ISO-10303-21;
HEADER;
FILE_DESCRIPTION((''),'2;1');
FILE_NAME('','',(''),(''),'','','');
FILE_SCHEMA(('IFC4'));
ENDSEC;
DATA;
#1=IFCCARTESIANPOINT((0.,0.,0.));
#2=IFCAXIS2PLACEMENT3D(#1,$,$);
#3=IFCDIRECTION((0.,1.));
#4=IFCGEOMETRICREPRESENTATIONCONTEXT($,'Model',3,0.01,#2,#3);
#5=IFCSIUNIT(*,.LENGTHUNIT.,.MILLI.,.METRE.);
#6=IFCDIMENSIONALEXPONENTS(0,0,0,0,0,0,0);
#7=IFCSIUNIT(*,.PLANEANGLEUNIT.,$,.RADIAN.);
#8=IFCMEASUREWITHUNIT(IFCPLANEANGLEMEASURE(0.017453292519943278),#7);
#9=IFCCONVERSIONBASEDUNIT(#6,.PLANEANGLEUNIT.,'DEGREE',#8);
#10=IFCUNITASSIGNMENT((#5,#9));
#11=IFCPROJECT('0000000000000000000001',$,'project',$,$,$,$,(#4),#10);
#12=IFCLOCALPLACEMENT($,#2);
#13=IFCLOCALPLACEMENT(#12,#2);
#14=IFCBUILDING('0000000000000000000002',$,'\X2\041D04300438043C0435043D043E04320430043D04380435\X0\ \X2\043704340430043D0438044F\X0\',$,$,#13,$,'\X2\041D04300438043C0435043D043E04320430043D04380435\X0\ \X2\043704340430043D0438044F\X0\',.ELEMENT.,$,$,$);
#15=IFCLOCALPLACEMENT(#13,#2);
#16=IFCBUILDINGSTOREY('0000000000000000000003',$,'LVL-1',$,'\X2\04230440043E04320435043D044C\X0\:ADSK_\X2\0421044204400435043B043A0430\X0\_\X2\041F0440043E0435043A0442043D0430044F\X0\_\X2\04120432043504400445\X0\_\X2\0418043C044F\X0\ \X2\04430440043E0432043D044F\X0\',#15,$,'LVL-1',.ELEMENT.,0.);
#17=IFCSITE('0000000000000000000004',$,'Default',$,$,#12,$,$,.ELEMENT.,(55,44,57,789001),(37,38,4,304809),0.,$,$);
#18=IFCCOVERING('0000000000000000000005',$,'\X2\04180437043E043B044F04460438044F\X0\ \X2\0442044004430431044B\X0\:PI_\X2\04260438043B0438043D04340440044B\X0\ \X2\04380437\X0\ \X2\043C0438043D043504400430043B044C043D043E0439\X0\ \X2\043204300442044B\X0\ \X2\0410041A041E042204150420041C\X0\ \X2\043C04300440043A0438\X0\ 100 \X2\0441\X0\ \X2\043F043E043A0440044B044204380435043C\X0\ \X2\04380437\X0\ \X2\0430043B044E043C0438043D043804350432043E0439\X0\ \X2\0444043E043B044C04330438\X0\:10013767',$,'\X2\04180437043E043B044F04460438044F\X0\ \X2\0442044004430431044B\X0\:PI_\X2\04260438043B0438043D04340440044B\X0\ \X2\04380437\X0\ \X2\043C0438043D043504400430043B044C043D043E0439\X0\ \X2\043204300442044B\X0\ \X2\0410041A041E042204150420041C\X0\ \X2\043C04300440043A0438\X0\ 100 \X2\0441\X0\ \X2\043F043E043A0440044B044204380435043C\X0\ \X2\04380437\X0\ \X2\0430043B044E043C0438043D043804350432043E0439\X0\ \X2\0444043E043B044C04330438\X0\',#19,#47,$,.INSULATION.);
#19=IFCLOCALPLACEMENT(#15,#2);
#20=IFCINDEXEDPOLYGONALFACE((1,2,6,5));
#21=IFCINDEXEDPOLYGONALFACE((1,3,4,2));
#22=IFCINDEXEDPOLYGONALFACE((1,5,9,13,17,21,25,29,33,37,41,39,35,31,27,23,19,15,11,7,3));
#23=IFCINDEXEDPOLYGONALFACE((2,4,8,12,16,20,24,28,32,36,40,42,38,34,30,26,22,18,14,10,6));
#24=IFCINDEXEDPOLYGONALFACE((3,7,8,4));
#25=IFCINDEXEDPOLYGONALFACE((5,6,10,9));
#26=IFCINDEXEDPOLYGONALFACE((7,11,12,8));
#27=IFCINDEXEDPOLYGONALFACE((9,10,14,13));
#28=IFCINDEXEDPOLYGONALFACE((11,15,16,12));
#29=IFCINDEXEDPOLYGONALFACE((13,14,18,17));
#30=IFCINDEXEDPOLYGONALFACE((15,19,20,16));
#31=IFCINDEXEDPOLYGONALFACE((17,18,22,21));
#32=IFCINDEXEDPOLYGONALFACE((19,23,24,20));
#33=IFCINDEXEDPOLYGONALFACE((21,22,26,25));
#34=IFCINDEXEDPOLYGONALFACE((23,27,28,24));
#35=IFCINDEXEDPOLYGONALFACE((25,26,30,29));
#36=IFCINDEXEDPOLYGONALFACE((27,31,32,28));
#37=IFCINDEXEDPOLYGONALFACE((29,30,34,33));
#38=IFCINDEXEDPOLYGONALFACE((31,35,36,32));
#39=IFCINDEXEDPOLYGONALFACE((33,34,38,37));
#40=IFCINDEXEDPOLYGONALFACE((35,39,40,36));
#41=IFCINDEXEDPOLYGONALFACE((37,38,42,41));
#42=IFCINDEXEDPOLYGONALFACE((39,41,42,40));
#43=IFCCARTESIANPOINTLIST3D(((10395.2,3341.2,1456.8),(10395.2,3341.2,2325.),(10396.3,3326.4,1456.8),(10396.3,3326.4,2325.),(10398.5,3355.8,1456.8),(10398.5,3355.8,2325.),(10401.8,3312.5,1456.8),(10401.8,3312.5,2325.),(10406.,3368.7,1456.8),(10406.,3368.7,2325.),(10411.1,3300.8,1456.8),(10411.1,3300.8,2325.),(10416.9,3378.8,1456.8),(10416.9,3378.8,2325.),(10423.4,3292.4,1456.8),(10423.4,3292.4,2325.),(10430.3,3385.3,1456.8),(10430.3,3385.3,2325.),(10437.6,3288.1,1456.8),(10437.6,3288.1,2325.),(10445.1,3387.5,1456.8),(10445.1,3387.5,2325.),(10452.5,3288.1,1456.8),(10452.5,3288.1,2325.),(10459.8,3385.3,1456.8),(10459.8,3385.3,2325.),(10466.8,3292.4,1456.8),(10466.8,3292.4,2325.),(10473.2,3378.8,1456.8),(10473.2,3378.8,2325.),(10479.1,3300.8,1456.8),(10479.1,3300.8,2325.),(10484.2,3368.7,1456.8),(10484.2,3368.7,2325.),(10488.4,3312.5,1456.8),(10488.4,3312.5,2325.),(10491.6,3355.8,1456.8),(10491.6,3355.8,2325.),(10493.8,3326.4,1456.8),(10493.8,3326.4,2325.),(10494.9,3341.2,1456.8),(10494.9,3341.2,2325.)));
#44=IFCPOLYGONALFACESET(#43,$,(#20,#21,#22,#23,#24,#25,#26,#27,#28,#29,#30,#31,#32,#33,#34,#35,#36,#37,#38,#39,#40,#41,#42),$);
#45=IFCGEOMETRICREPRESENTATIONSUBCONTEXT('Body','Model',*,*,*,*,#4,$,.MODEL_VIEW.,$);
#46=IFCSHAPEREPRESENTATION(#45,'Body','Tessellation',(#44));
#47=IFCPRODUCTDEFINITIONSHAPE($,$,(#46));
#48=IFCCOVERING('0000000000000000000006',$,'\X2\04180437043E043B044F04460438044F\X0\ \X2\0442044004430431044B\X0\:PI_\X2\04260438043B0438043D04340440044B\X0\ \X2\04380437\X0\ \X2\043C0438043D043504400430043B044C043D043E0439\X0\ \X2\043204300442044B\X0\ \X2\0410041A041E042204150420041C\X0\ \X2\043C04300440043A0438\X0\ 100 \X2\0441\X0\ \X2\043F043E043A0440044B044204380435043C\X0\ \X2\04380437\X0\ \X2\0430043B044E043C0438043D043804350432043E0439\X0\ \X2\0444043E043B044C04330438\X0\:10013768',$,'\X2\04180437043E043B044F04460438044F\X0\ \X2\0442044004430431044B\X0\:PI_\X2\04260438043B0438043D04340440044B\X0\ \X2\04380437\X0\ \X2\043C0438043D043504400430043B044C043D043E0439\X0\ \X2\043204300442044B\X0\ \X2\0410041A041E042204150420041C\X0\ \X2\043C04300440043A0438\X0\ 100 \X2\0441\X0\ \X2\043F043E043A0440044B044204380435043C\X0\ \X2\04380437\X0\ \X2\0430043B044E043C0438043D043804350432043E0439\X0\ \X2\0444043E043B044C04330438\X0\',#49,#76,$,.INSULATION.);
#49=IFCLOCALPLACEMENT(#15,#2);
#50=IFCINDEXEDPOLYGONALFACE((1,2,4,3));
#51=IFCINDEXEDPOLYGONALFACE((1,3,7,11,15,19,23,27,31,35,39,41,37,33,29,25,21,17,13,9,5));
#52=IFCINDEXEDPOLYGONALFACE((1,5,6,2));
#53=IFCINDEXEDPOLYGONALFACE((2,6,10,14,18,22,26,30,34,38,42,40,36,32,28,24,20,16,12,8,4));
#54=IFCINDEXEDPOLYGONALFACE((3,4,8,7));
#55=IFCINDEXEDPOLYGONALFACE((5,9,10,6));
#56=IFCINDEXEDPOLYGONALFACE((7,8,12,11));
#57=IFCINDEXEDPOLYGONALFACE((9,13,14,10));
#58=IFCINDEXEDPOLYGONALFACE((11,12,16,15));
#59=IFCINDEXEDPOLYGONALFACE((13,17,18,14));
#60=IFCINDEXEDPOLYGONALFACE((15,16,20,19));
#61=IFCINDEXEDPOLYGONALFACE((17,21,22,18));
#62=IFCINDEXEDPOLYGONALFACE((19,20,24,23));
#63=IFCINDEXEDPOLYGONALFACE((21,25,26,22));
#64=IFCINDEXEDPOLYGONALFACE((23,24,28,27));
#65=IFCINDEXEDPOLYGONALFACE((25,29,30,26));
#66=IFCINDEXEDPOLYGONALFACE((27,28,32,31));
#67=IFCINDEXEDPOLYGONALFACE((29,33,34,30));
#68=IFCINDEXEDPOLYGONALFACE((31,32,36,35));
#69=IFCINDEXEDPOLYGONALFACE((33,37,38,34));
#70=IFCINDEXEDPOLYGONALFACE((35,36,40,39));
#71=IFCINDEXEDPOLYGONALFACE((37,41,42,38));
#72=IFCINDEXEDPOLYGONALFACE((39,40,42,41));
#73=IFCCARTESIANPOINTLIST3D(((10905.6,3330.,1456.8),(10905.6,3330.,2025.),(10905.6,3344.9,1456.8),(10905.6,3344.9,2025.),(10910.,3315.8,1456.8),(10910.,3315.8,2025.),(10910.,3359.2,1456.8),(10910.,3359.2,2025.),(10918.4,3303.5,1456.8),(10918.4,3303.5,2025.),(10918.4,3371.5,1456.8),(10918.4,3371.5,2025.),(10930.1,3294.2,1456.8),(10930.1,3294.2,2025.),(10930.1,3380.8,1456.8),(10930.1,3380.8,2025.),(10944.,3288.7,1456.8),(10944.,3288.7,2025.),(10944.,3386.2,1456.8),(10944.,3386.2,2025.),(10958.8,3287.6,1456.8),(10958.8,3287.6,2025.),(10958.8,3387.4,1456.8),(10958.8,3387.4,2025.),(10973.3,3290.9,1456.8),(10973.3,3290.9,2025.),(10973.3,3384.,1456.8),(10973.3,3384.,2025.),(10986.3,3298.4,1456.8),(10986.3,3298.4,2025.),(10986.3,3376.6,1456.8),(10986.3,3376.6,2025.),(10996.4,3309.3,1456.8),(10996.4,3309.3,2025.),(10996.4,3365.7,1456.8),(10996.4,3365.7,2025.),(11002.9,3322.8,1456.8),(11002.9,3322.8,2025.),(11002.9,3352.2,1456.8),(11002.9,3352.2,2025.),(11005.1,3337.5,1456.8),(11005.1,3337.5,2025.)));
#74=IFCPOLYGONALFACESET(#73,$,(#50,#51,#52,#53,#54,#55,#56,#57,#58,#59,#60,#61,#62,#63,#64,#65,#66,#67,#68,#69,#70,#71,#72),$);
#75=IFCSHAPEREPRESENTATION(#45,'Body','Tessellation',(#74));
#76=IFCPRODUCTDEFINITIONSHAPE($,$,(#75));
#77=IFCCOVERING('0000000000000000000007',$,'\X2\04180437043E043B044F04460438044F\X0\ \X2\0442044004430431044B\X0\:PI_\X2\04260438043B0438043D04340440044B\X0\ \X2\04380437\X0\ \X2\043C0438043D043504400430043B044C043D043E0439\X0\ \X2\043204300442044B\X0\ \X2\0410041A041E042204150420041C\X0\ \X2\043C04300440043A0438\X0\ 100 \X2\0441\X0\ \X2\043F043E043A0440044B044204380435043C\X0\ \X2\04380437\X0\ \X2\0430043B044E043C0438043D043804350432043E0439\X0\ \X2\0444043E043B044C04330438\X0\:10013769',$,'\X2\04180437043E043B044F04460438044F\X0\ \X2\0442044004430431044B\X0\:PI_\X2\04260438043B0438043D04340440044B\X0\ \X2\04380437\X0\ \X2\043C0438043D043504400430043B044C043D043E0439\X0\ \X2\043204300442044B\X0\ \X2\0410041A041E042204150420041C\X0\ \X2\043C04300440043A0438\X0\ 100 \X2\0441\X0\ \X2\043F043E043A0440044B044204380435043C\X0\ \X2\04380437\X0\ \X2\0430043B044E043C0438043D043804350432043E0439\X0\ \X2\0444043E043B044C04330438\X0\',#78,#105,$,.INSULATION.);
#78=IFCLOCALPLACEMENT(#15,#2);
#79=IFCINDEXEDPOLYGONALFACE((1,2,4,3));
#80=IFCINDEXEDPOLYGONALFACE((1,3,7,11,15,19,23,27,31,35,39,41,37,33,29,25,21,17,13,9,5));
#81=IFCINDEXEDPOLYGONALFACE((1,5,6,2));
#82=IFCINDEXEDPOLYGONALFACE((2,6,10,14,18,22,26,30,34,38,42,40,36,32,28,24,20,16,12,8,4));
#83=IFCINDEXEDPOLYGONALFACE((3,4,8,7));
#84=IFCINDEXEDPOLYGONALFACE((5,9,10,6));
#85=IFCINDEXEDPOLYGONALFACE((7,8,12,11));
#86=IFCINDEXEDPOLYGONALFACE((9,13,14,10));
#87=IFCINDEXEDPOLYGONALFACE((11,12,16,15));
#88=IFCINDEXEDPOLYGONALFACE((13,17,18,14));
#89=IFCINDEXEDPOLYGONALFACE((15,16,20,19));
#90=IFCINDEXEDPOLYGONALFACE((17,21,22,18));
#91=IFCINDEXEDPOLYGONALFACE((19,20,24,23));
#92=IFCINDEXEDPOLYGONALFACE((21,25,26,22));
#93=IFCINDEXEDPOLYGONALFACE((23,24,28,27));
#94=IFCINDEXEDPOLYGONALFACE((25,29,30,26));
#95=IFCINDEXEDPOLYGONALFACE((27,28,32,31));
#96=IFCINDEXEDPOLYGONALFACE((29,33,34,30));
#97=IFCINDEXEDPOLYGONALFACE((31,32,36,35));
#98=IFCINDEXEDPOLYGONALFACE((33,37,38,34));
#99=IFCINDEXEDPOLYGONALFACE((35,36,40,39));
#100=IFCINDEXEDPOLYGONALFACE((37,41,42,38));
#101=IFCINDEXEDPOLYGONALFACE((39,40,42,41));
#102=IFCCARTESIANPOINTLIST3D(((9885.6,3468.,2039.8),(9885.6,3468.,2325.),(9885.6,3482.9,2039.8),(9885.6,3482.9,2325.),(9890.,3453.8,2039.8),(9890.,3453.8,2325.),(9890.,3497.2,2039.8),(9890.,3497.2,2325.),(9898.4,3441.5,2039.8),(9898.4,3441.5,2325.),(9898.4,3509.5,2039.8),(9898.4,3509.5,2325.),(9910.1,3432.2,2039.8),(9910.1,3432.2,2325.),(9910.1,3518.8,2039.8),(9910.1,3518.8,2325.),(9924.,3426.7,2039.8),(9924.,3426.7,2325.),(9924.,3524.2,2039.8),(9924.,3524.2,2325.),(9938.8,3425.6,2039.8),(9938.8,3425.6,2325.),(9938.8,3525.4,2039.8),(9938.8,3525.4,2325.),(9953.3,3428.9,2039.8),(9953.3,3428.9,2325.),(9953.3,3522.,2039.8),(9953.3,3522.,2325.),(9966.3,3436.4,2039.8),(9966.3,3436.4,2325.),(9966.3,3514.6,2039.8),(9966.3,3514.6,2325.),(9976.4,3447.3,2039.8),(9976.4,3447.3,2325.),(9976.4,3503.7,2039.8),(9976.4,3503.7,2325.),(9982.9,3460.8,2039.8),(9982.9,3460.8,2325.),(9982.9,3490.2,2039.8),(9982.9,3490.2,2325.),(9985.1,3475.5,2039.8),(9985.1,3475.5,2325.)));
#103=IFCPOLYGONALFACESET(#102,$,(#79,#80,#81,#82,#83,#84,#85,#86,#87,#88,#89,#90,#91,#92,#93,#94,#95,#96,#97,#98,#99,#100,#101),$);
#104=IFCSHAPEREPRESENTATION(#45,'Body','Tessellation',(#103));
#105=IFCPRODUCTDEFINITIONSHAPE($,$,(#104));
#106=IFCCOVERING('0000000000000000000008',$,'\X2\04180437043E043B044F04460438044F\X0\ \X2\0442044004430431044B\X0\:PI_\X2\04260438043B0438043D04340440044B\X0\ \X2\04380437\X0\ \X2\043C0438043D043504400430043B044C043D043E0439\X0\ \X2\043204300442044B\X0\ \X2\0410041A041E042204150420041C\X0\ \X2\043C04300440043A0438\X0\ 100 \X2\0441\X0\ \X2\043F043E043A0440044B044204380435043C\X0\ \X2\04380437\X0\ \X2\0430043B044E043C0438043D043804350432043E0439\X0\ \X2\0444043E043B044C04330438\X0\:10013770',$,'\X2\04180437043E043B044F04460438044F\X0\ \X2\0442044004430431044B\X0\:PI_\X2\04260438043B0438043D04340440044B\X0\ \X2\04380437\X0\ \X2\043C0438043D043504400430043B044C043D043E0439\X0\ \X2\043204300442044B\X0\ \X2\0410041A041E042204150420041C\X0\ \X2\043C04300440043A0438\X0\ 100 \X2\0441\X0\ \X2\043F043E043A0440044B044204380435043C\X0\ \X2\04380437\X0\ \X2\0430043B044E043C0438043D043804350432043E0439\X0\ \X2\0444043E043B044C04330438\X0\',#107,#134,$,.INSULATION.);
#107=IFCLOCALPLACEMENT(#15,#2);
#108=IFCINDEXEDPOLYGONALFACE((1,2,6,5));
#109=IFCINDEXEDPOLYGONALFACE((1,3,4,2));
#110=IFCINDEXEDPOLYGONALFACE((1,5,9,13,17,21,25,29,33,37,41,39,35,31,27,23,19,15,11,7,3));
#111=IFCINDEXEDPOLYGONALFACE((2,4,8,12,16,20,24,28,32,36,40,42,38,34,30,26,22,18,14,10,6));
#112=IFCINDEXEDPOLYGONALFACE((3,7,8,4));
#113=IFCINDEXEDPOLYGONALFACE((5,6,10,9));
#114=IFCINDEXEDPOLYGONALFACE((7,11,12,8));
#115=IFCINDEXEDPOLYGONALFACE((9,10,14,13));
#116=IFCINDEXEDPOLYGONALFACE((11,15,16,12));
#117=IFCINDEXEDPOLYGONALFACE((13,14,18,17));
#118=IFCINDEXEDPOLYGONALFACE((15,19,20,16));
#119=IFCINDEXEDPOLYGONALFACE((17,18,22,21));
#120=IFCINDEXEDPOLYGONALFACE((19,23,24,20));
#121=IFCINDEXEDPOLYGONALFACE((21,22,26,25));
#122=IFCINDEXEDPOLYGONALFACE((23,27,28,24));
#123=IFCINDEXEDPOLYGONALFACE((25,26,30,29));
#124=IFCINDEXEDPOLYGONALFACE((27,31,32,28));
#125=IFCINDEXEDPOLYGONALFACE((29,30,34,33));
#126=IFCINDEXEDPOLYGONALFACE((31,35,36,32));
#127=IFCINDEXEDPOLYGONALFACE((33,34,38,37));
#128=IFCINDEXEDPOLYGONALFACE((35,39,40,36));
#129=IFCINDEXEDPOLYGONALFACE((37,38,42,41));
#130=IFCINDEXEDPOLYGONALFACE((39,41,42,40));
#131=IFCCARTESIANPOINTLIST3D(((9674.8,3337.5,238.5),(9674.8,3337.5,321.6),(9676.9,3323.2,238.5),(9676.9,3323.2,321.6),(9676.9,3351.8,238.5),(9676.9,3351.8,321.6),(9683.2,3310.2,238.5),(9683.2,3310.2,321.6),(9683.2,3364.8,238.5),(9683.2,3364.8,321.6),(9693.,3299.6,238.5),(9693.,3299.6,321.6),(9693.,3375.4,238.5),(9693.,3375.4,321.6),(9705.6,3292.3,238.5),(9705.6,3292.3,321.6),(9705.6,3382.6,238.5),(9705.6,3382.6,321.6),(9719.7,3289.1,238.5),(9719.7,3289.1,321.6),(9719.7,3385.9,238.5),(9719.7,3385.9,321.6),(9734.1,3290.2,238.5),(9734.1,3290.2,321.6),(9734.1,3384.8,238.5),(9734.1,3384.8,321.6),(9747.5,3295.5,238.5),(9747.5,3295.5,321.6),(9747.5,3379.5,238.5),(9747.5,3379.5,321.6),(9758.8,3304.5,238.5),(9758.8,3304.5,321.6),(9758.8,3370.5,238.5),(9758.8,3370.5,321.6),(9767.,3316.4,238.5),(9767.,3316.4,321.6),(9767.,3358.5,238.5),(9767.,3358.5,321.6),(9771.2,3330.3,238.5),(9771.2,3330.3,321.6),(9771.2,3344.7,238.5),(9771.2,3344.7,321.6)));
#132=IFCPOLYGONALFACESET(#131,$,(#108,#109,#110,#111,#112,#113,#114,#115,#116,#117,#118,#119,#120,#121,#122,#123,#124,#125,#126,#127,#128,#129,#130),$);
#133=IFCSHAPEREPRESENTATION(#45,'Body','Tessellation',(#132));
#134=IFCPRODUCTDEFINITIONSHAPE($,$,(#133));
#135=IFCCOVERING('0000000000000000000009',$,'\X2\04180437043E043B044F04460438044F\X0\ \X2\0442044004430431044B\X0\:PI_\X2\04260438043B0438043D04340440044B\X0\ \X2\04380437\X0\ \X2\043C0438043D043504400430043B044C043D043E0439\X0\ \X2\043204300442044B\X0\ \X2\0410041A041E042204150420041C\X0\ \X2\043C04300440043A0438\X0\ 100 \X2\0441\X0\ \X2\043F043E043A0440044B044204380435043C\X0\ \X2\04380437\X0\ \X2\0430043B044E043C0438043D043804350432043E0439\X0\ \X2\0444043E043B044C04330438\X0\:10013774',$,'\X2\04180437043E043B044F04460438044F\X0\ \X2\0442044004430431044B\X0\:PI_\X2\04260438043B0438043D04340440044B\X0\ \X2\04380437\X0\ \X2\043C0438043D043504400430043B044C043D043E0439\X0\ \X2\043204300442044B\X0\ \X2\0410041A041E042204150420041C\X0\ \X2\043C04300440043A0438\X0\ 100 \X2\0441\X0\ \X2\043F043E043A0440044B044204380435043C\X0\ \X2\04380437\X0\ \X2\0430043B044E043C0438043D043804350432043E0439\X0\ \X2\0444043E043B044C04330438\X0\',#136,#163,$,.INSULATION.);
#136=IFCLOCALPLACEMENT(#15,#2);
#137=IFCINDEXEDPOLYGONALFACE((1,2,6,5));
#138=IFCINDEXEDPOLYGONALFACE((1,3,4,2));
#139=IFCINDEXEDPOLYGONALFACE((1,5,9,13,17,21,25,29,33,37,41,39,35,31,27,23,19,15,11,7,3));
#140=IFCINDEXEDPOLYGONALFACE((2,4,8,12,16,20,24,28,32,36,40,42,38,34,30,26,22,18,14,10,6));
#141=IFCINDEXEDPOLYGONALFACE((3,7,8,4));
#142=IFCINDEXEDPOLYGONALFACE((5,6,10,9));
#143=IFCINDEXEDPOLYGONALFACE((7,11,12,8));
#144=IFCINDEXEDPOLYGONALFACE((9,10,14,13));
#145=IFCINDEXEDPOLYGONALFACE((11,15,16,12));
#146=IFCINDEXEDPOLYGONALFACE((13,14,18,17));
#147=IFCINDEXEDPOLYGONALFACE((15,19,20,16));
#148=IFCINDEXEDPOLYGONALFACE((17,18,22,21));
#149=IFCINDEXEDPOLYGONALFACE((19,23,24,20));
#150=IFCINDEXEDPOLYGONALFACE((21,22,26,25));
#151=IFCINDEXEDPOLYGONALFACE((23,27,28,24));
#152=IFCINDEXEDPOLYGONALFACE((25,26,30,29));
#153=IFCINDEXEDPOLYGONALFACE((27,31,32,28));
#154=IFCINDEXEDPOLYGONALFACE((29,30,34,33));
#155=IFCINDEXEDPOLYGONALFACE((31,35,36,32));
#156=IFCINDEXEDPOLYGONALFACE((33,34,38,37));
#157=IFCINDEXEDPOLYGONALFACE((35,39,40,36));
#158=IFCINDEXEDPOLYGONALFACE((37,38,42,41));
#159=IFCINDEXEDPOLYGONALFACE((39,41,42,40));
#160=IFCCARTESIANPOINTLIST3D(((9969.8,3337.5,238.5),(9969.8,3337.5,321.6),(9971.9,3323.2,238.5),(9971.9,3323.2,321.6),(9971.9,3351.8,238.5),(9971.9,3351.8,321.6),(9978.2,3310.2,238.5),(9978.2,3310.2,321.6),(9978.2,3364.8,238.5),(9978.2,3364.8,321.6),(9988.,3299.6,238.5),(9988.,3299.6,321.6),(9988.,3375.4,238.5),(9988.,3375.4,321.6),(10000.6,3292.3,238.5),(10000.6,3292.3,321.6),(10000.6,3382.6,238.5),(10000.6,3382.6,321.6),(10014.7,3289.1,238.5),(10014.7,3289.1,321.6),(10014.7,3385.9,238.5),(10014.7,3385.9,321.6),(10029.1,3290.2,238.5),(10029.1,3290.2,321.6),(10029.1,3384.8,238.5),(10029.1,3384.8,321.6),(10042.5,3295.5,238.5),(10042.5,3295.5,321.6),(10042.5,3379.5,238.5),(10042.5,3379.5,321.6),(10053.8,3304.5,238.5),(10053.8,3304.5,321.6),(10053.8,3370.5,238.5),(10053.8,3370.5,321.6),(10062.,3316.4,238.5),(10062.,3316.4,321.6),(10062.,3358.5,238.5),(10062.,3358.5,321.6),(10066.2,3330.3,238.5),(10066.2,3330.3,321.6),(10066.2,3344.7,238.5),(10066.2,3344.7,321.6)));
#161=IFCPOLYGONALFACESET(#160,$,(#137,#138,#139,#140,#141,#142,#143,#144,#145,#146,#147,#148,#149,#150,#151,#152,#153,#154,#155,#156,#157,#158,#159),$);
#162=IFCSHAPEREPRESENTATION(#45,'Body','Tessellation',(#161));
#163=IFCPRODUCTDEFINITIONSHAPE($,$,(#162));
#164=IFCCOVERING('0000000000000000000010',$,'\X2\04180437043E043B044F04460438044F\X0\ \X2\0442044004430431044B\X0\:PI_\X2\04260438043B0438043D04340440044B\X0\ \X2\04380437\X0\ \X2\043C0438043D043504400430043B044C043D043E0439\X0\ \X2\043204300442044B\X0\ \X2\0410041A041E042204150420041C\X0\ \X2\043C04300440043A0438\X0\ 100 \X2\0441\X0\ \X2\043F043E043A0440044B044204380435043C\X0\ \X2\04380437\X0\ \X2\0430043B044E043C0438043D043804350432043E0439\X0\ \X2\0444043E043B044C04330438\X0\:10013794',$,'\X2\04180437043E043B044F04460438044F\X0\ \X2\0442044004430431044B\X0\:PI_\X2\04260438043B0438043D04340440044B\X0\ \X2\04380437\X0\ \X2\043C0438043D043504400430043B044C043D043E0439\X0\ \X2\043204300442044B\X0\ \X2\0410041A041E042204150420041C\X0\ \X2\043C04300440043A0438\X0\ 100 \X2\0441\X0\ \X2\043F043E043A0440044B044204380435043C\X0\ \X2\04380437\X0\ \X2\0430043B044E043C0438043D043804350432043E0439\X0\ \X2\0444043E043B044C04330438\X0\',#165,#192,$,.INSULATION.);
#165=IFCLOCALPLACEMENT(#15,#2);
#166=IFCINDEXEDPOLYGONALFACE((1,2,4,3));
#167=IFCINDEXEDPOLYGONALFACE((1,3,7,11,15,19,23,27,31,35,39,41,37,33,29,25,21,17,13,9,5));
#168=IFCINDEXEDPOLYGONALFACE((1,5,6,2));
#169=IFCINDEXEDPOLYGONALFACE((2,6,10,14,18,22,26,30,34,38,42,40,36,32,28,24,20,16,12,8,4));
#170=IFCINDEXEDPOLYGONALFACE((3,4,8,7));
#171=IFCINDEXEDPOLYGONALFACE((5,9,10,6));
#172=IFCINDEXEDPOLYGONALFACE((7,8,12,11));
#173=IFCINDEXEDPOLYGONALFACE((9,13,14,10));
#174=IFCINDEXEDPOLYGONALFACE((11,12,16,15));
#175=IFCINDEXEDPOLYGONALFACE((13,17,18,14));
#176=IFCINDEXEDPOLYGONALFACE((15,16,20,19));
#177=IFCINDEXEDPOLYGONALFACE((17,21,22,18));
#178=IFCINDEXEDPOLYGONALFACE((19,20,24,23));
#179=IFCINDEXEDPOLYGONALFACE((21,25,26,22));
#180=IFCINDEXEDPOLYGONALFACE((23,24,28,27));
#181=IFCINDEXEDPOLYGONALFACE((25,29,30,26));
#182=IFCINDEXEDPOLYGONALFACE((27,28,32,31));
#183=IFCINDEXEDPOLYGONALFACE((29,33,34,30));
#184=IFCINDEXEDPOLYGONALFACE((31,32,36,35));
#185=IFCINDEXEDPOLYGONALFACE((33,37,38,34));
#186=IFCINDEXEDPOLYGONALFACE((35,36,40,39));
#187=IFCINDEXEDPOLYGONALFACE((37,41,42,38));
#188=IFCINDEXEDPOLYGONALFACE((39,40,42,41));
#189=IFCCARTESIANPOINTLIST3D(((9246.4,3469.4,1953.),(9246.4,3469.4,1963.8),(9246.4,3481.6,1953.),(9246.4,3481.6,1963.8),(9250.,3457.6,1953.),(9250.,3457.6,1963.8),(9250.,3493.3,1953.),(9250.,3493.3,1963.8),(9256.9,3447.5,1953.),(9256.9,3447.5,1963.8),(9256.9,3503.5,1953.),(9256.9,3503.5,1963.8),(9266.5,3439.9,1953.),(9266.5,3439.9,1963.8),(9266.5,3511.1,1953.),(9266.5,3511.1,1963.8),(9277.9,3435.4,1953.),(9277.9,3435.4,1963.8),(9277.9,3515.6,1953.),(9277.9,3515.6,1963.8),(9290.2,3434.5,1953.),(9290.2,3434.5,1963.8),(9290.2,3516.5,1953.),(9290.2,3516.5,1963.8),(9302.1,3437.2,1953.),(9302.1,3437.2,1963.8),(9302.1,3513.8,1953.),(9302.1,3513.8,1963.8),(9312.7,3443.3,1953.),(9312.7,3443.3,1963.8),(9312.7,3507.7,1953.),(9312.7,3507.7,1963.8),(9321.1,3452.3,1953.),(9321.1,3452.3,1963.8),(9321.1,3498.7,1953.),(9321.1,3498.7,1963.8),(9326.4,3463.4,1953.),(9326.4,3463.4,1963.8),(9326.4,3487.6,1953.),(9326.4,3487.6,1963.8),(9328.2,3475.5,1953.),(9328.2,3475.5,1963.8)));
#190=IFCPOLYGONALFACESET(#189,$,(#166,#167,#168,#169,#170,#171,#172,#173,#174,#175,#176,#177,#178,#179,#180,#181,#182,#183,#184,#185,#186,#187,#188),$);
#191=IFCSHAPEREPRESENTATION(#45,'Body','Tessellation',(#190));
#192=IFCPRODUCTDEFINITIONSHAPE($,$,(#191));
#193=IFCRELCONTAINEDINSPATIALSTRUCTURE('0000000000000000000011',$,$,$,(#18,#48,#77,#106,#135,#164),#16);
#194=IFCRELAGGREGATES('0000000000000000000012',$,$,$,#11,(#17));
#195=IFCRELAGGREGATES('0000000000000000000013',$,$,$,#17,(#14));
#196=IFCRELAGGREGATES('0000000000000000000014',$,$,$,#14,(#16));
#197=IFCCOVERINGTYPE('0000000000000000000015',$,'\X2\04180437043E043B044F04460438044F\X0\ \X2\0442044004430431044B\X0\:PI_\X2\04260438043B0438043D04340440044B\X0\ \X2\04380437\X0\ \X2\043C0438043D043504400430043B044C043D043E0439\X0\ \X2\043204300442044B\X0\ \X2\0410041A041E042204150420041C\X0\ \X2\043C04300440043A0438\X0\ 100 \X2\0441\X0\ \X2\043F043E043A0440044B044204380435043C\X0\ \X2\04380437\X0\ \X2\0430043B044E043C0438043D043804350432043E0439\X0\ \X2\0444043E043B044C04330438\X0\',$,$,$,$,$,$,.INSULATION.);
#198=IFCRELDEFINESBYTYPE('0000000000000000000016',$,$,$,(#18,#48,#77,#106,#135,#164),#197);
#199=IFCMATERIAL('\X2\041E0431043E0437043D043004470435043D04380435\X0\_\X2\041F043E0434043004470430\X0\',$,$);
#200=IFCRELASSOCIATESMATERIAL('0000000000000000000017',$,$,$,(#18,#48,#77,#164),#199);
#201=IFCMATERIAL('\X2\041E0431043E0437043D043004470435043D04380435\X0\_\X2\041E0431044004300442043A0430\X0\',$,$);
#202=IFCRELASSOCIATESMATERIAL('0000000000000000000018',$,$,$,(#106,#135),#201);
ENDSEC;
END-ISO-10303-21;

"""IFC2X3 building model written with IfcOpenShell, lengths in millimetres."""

from ifc_helpers import new_model, entity, si_unit, converted_unit, direction, frame, frame_2d, origin, origin_2d_with_axis, place, context, subcontext, project, spatial, circle, extrude, material, type_object, element, save


model = new_model("IFC2X3")

# Units and contexts
model_context = context("Model", 3, precision=0.01, world=origin(), true_north=direction((0.0, 1.0)))
body_context = subcontext(model_context, "Body", "Model", "MODEL_VIEW")
ifc_project = project(units=[si_unit("LENGTHUNIT", "METRE", prefix="MILLI"), converted_unit("PLANEANGLEUNIT", "DEGREE", entity("IfcPlaneAngleMeasure", 0.017453292519943278), si_unit("PLANEANGLEUNIT", "RADIAN"), dimensions=[0, 0, 0, 0, 0, 0, 0])], contexts=[model_context])

# Site, building, storey
site_placement = place(None, origin())
site = spatial("IfcSite", under=ifc_project, at=site_placement, Name="Default", CompositionType="ELEMENT", RefLatitude=(55, 44, 57, 789001), RefLongitude=(37, 38, 4, 304809), RefElevation=0.0)
building_placement = place(site_placement, origin())
building = spatial("IfcBuilding", under=site, at=building_placement, Name="Наименование здания", LongName="Наименование здания", CompositionType="ELEMENT")
storey_placement = place(building_placement, origin())
storey = spatial("IfcBuildingStorey", under=building, at=storey_placement, Name="LVL-1", ObjectType="Уровень:ADSK_Стрелка_Проектная_Вверх_Имя уровня", LongName="LVL-1", CompositionType="ELEMENT", Elevation=0.0)

# Coverings
ifc_material_1 = material(Name="Обозначение_Подача")
covering_type = type_object("IfcCoveringType", Name="Изоляция трубы:PI_Цилиндры из минеральной ваты АКОТЕРМ марки 100 с покрытием из алюминиевой фольги", PredefinedType="INSULATION")
covering_1_placement = place(storey_placement, origin())
element("IfcCovering", 1, at=covering_1_placement, inside=storey, type_object=covering_type, material=ifc_material_1, Name="Изоляция трубы:PI_Цилиндры из минеральной ваты АКОТЕРМ марки 100 с покрытием из алюминиевой фольги:10013767", ObjectType="Изоляция трубы:PI_Цилиндры из минеральной ваты АКОТЕРМ марки 100 с покрытием из алюминиевой фольги", PredefinedType="INSULATION", context=body_context, shape_type="SweptSolid", body=[
    extrude(circle(Radius=50.0, at=frame_2d((0.0, 0.0), x_axis=(1.0, 0.0))), frame((10445.1, 3337.5, 1456.8), z_axis=(0.0, 0.0, 1.0), x_axis=(0.0, 1.0, 0.0)), (0.0, 0.0, 1.0), 868.2),
])
covering_2_placement = place(storey_placement, origin())
element("IfcCovering", 2, at=covering_2_placement, inside=storey, type_object=covering_type, material=ifc_material_1, Name="Изоляция трубы:PI_Цилиндры из минеральной ваты АКОТЕРМ марки 100 с покрытием из алюминиевой фольги:10013768", ObjectType="Изоляция трубы:PI_Цилиндры из минеральной ваты АКОТЕРМ марки 100 с покрытием из алюминиевой фольги", PredefinedType="INSULATION", context=body_context, shape_type="SweptSolid", body=[
    extrude(circle(Radius=50.0, at=frame_2d((0.0, 0.0), x_axis=(1.0, 0.0))), frame((10955.1, 3337.5, 1456.8)), (0.0, 0.0, 1.0), 568.2),
])
covering_3_placement = place(storey_placement, origin())
element("IfcCovering", 3, at=covering_3_placement, inside=storey, type_object=covering_type, material=ifc_material_1, Name="Изоляция трубы:PI_Цилиндры из минеральной ваты АКОТЕРМ марки 100 с покрытием из алюминиевой фольги:10013769", ObjectType="Изоляция трубы:PI_Цилиндры из минеральной ваты АКОТЕРМ марки 100 с покрытием из алюминиевой фольги", PredefinedType="INSULATION", context=body_context, shape_type="SweptSolid", body=[
    extrude(circle(Radius=50.0, at=frame_2d((0.0, 0.0), x_axis=(1.0, 0.0))), frame((9935.1, 3475.5, 2039.8)), (0.0, 0.0, 1.0), 285.2),
])
ifc_material_2 = material(Name="Обозначение_Обратка")
covering_4_placement = place(storey_placement, origin())
element("IfcCovering", 4, at=covering_4_placement, inside=storey, type_object=covering_type, material=ifc_material_2, Name="Изоляция трубы:PI_Цилиндры из минеральной ваты АКОТЕРМ марки 100 с покрытием из алюминиевой фольги:10013770", ObjectType="Изоляция трубы:PI_Цилиндры из минеральной ваты АКОТЕРМ марки 100 с покрытием из алюминиевой фольги", PredefinedType="INSULATION", context=body_context, shape_type="SweptSolid", body=[
    extrude(circle(Radius=48.5, at=frame_2d((0.0, 0.0), x_axis=(1.0, 0.0))), frame((9723.3, 3337.5, 238.5), z_axis=(0.0, 0.0, 1.0), x_axis=(-1.0, 0.0, 0.0)), (0.0, 0.0, 1.0), 83.1),
])
covering_5_placement = place(storey_placement, origin())
element("IfcCovering", 5, at=covering_5_placement, inside=storey, type_object=covering_type, material=ifc_material_2, Name="Изоляция трубы:PI_Цилиндры из минеральной ваты АКОТЕРМ марки 100 с покрытием из алюминиевой фольги:10013774", ObjectType="Изоляция трубы:PI_Цилиндры из минеральной ваты АКОТЕРМ марки 100 с покрытием из алюминиевой фольги", PredefinedType="INSULATION", context=body_context, shape_type="SweptSolid", body=[
    extrude(circle(Radius=48.5, at=origin_2d_with_axis()), frame((10018.3, 3337.5, 238.5), z_axis=(0.0, 0.0, 1.0), x_axis=(-1.0, 0.0, 0.0)), (0.0, 0.0, 1.0), 83.1),
])
covering_6_placement = place(storey_placement, origin())
element("IfcCovering", 6, at=covering_6_placement, inside=storey, type_object=covering_type, material=ifc_material_1, Name="Изоляция трубы:PI_Цилиндры из минеральной ваты АКОТЕРМ марки 100 с покрытием из алюминиевой фольги:10013794", ObjectType="Изоляция трубы:PI_Цилиндры из минеральной ваты АКОТЕРМ марки 100 с покрытием из алюминиевой фольги", PredefinedType="INSULATION", context=body_context, shape_type="SweptSolid", body=[
    extrude(circle(Radius=41.1, at=frame_2d((0.0, 0.0), x_axis=(1.0, 0.0))), frame((9287.1, 3475.5, 1953.0)), (0.0, 0.0, 1.0), 10.8),
])

save(model, "model.ifc")
